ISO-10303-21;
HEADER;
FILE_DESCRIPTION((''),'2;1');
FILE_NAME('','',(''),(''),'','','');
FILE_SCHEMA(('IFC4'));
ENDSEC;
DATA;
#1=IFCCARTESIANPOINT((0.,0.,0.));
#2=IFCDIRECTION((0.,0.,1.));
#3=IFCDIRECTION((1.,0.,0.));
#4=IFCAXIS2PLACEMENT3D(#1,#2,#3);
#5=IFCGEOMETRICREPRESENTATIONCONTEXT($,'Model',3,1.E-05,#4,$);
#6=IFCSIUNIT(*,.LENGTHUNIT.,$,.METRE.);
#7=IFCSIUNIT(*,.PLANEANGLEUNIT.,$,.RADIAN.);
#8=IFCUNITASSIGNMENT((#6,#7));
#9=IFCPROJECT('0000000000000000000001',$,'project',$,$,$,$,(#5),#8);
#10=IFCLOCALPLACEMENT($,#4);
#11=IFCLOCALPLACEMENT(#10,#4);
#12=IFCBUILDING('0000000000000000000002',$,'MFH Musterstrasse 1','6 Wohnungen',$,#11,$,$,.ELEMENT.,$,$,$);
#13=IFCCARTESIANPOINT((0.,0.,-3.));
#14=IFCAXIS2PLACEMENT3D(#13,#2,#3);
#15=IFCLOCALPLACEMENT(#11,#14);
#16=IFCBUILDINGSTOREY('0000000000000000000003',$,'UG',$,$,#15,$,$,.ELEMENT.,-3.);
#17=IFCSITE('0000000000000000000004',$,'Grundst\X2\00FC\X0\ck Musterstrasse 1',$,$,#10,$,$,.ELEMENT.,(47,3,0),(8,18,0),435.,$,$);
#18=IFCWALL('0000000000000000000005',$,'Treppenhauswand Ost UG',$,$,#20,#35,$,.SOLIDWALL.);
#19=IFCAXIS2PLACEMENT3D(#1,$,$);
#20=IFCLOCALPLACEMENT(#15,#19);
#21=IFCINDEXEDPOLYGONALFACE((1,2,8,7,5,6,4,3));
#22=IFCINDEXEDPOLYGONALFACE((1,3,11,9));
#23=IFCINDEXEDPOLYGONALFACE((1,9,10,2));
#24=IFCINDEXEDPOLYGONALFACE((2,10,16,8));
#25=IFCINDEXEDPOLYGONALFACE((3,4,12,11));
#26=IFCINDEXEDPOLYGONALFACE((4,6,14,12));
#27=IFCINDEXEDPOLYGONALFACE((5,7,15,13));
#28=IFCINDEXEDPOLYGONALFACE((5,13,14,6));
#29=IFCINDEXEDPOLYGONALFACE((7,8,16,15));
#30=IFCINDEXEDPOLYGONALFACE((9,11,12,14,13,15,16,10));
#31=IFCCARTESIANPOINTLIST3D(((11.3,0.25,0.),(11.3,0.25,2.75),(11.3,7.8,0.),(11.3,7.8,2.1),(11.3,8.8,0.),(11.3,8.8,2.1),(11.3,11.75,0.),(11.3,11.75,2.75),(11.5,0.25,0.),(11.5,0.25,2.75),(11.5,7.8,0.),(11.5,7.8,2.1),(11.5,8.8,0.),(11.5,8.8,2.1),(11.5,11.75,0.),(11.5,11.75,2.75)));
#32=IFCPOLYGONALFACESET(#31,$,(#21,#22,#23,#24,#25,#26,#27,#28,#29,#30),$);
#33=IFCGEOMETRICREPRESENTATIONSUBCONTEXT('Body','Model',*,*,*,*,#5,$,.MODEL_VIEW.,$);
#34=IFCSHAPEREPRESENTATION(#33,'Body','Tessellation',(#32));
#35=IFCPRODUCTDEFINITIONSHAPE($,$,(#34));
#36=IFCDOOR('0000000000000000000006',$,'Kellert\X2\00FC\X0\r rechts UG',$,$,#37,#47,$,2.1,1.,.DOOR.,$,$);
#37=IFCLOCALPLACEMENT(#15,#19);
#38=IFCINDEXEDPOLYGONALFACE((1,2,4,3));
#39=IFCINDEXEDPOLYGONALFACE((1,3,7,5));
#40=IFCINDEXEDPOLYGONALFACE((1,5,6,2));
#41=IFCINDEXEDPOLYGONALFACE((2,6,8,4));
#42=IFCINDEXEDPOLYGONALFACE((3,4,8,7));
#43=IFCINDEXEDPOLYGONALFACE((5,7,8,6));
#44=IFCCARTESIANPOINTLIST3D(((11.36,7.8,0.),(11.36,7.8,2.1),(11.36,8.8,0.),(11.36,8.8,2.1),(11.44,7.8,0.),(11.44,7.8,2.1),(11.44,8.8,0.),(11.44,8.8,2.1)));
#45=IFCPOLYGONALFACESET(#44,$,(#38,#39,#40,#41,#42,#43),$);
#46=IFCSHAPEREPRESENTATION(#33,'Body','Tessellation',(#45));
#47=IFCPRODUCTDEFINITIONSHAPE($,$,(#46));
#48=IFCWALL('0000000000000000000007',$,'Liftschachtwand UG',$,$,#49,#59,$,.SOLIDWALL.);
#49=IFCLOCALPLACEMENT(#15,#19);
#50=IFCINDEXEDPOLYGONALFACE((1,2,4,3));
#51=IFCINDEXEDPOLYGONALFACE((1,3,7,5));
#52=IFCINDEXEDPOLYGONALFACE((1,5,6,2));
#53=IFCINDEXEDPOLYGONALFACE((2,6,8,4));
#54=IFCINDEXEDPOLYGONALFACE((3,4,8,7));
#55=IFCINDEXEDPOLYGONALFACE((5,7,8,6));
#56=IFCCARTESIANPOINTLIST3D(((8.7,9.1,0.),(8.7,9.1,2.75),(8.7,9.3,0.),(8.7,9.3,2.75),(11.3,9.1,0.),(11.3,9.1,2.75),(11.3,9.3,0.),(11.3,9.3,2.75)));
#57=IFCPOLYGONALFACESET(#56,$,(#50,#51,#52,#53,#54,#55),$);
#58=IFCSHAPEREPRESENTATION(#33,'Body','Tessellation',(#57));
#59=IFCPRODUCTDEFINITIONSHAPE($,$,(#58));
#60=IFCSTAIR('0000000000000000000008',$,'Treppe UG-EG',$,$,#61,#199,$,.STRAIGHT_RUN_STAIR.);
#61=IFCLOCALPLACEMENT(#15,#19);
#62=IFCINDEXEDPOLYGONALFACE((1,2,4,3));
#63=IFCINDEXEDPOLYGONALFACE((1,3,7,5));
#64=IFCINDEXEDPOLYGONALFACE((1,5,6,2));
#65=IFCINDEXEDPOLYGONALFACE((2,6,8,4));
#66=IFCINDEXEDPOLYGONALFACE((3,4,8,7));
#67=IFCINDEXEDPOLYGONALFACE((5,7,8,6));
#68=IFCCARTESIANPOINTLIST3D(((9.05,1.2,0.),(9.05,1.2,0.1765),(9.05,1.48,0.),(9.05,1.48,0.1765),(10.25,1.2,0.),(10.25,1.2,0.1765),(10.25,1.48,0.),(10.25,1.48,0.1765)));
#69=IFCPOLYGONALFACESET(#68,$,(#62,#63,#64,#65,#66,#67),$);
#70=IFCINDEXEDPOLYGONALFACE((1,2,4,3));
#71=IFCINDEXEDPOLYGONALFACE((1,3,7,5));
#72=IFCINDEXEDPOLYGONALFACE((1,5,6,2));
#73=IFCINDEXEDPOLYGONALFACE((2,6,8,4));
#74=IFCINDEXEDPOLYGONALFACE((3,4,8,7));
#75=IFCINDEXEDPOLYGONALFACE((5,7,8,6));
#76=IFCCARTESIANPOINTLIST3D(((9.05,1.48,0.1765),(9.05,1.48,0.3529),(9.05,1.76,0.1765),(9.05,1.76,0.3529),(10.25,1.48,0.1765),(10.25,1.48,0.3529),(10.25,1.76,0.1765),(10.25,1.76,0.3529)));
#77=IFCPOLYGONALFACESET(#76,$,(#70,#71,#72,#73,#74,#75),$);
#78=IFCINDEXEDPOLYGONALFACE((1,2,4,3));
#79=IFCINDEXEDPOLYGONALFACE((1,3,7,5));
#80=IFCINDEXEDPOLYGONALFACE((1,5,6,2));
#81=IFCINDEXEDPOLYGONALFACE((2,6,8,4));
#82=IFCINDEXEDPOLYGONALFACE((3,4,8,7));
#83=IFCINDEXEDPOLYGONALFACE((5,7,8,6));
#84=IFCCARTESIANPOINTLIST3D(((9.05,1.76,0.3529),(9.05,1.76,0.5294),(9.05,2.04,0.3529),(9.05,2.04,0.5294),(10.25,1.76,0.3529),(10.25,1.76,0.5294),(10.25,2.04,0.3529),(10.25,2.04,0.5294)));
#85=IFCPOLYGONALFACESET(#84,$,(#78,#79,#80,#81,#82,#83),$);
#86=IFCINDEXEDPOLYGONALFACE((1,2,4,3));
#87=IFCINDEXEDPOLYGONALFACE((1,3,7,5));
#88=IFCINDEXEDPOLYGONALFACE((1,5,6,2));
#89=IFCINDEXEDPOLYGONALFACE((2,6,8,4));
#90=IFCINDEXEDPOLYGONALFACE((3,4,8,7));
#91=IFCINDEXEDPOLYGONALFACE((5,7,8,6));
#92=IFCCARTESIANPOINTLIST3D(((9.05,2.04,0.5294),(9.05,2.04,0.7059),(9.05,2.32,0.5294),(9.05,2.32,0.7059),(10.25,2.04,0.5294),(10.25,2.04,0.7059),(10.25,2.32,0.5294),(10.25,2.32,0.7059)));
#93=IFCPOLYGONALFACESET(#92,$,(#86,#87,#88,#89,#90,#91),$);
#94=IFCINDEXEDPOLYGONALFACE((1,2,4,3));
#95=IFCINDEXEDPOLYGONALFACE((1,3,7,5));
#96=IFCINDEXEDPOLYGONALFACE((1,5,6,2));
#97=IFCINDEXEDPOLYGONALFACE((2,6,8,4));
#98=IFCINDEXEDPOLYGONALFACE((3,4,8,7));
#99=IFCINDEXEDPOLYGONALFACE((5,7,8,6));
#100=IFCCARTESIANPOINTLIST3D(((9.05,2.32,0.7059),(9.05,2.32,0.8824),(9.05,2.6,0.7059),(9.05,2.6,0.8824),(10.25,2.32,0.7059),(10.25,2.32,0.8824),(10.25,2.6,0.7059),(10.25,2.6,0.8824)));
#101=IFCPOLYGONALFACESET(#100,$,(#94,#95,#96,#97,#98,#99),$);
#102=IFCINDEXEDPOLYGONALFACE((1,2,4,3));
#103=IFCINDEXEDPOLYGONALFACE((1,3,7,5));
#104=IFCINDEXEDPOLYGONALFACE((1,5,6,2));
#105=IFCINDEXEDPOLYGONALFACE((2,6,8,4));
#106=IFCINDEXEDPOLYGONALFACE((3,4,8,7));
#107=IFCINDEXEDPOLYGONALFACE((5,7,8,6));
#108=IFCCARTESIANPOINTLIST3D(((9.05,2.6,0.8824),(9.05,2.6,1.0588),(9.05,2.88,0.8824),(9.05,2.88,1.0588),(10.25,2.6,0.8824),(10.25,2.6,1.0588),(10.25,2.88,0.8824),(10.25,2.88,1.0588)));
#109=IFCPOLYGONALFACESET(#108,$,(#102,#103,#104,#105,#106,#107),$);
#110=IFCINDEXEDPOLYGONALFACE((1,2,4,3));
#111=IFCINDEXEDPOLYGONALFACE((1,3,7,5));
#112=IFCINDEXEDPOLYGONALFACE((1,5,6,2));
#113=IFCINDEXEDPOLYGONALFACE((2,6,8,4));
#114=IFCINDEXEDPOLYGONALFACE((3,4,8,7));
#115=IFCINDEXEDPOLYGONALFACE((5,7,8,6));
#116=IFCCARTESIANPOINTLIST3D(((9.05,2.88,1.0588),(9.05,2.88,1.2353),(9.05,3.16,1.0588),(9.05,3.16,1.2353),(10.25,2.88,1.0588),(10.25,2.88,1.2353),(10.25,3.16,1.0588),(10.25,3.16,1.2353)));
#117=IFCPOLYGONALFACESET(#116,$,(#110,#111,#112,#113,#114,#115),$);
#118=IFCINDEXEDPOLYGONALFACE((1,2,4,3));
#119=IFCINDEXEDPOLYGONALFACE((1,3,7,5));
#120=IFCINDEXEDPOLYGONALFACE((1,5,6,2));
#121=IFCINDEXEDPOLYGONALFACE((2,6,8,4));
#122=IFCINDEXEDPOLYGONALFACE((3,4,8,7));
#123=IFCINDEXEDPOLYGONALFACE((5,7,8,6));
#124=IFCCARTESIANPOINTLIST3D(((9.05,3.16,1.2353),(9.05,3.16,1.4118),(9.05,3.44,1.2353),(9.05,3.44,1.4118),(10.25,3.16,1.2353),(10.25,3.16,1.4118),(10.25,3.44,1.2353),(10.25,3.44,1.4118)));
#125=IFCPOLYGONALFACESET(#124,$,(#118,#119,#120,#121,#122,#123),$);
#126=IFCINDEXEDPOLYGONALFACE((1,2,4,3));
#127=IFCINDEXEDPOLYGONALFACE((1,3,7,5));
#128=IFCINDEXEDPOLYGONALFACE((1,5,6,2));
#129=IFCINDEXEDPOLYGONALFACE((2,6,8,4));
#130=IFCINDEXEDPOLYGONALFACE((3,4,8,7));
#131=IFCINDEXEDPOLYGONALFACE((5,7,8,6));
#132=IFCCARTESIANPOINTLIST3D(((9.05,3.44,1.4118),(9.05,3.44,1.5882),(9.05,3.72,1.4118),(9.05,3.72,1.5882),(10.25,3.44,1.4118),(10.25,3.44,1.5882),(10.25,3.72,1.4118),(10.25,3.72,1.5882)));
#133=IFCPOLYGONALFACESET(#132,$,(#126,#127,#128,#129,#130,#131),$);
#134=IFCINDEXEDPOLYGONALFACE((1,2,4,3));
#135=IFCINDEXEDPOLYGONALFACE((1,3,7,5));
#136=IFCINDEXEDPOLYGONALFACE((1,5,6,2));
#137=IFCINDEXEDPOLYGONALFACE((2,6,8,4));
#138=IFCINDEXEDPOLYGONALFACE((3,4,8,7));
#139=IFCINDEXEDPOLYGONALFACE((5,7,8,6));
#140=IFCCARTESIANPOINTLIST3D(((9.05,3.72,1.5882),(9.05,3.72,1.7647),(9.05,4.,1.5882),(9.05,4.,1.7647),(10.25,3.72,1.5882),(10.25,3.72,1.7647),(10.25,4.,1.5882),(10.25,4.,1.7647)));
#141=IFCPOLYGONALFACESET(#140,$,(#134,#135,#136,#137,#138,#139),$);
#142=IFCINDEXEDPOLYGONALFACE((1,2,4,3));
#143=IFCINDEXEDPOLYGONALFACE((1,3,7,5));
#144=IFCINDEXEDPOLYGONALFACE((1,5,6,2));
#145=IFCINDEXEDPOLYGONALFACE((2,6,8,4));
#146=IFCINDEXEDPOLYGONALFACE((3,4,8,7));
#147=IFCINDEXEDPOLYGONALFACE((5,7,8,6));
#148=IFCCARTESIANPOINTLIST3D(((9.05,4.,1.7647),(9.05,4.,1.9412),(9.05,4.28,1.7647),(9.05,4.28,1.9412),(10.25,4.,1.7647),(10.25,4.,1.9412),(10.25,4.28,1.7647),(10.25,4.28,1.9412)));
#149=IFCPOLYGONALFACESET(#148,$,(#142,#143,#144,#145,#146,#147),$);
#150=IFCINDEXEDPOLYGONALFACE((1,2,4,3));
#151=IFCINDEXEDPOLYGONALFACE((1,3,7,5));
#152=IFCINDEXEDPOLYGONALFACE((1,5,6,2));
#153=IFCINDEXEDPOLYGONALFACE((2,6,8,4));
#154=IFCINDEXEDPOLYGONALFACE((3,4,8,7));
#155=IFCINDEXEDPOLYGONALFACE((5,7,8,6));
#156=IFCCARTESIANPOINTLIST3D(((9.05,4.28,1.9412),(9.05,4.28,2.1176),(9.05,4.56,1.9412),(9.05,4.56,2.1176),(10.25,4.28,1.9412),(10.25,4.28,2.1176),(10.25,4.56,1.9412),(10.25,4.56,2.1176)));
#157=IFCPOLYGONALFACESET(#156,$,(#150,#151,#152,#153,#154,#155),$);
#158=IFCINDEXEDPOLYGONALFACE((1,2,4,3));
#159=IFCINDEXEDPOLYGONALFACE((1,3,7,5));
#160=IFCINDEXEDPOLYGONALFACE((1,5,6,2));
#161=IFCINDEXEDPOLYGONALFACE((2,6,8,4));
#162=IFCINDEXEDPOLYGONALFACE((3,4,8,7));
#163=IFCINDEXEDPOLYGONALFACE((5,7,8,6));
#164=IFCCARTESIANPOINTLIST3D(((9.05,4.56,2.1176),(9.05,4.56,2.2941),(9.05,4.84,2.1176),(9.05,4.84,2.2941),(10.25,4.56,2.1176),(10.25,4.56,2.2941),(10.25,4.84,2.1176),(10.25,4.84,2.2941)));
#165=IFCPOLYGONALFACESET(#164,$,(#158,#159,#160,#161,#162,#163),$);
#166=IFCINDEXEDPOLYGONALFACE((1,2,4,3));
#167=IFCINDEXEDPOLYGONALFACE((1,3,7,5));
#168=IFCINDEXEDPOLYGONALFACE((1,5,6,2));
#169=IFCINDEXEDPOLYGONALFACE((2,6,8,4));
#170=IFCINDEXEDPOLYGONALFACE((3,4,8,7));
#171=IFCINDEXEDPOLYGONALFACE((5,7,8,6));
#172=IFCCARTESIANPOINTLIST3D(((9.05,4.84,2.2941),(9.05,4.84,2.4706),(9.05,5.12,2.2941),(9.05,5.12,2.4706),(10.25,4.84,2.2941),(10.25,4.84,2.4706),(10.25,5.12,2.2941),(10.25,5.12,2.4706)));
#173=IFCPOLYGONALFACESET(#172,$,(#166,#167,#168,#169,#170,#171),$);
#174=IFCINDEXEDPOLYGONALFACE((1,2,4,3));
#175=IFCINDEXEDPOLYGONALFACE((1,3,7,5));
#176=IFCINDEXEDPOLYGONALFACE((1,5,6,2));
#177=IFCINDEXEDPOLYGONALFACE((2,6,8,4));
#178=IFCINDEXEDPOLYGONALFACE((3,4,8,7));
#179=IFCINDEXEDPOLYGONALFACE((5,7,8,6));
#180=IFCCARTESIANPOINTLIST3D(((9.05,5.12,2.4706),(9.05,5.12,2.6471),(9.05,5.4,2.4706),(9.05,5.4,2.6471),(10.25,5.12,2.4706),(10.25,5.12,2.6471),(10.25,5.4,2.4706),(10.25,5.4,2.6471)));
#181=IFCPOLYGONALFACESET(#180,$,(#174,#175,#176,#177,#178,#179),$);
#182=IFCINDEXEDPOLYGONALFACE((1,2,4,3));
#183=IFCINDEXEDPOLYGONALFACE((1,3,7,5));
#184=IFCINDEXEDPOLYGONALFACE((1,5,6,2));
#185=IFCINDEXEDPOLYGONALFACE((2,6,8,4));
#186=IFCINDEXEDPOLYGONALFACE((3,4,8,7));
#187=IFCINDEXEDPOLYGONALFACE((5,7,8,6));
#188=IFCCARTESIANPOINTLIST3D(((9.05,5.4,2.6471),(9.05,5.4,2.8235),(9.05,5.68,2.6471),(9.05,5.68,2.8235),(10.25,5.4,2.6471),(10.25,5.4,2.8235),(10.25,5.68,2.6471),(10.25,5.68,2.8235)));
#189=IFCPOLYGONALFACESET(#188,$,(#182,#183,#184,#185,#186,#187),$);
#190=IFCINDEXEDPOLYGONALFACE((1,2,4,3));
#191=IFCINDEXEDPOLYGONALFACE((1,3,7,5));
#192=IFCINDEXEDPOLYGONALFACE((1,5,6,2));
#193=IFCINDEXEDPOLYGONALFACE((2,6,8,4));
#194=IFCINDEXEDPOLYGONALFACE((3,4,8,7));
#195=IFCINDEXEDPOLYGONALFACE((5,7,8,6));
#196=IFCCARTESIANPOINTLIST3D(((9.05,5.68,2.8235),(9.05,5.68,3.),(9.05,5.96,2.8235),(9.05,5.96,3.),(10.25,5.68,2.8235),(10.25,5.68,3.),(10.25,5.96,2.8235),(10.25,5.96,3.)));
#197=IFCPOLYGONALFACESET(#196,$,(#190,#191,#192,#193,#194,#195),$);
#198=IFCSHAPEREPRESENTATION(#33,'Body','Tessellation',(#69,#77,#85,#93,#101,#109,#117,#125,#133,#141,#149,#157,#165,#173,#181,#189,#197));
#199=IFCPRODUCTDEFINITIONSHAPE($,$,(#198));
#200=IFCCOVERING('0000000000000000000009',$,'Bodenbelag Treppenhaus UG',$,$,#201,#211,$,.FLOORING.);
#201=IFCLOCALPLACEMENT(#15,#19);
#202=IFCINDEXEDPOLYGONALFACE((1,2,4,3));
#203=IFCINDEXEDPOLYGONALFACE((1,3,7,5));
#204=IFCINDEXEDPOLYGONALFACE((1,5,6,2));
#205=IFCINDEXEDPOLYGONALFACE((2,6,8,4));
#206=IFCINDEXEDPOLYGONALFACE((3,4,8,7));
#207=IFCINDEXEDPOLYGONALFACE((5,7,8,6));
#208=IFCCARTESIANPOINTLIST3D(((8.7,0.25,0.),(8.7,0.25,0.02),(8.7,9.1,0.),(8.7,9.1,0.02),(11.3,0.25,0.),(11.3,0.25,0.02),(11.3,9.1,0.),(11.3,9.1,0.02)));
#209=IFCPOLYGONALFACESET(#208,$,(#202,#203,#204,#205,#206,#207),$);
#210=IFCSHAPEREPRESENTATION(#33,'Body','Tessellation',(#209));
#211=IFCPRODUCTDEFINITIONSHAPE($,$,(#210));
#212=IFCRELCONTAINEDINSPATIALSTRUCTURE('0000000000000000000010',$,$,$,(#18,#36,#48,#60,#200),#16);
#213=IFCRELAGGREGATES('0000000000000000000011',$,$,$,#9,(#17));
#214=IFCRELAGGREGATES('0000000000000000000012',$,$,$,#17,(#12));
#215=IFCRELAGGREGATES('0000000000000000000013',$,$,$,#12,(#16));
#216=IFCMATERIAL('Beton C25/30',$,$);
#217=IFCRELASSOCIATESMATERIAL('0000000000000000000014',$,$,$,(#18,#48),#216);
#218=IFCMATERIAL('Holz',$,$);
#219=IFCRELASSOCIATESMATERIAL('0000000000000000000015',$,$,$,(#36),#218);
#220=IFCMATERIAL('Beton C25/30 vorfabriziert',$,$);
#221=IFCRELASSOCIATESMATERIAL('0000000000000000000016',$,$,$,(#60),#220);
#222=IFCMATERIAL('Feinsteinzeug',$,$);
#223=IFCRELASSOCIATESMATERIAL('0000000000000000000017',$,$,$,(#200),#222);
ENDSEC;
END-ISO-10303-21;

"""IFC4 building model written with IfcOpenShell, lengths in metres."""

from ifc_helpers import new_model, si_unit, frame, frame_2d, origin_with_axes, place, context, subcontext, project, spatial, rectangle, extrude, material, element, fill, save


model = new_model("IFC4")

# Units and contexts
model_context = context("Model", 3, precision=1e-05, world=origin_with_axes())
body_context = subcontext(model_context, "Body", "Model", "MODEL_VIEW")
ifc_project = project(units=[si_unit("LENGTHUNIT", "METRE"), si_unit("PLANEANGLEUNIT", "RADIAN")], contexts=[model_context])

# Site, building, storey
site_placement = place(None, origin_with_axes())
site = spatial("IfcSite", under=ifc_project, at=site_placement, Name="Grundstück Musterstrasse 1", CompositionType="ELEMENT", RefLatitude=(47, 3, 0), RefLongitude=(8, 18, 0), RefElevation=435.0)
building_placement = place(site_placement, origin_with_axes())
building = spatial("IfcBuilding", under=site, at=building_placement, Name="MFH Musterstrasse 1", Description="6 Wohnungen", CompositionType="ELEMENT")
storey_placement = place(building_placement, frame((0.0, 0.0, -3.0), z_axis=(0.0, 0.0, 1.0), x_axis=(1.0, 0.0, 0.0)))
storey = spatial("IfcBuildingStorey", under=building, at=storey_placement, Name="UG", CompositionType="ELEMENT", Elevation=-3.0)

# Shared definitions
ifc_material_1 = material(Name="Beton C25/30")

# Wall, openings, door
ifc_material_2 = material(Name="Holz")
wall_1_placement = place(storey_placement, origin_with_axes())
wall_1 = element("IfcWall", 1, at=wall_1_placement, inside=storey, material=ifc_material_1, Name="Treppenhauswand Ost UG", PredefinedType="SOLIDWALL", context=body_context, shape_type="SweptSolid", body=[
    extrude(rectangle(XDim=0.2, YDim=11.5, at=frame_2d((0.1, 5.75), x_axis=(1.0, 0.0))), frame((11.3, 0.25, 0.0), z_axis=(0.0, 0.0, 1.0), x_axis=(1.0, 0.0, 0.0)), (0.0, 0.0, 1.0), 2.75),
])
opening_1_placement = place(storey_placement, origin_with_axes())
element("IfcOpeningElement", 2, at=opening_1_placement, cuts=wall_1, PredefinedType="OPENING", context=body_context, shape_type="SweptSolid", body=[
    extrude(rectangle(XDim=0.3, YDim=1.0, at=frame_2d((0.15, 0.5), x_axis=(1.0, 0.0))), frame((11.25, 7.8, 0.0), z_axis=(0.0, 0.0, 1.0), x_axis=(1.0, 0.0, 0.0)), (0.0, 0.0, 1.0), 2.1),
])
opening_2_placement = place(storey_placement, origin_with_axes())
opening_2 = element("IfcOpeningElement", 3, at=opening_2_placement, cuts=wall_1, PredefinedType="OPENING", context=body_context, shape_type="SweptSolid", body=[
    extrude(rectangle(XDim=0.22, YDim=1.0, at=frame_2d((0.11, 0.5), x_axis=(1.0, 0.0))), frame((11.29, 7.8, 0.0), z_axis=(0.0, 0.0, 1.0), x_axis=(1.0, 0.0, 0.0)), (0.0, 0.0, 1.0), 2.1),
])
door_1_placement = place(storey_placement, origin_with_axes())
door_1 = element("IfcDoor", 4, at=door_1_placement, inside=storey, material=ifc_material_2, Name="Kellertür rechts UG", OverallHeight=2.1, OverallWidth=1.0, PredefinedType="DOOR", context=body_context, shape_type="SweptSolid", body=[
    extrude(rectangle(XDim=0.08, YDim=1.0, at=frame_2d((0.04, 0.5), x_axis=(1.0, 0.0))), frame((11.36, 7.8, 0.0), z_axis=(0.0, 0.0, 1.0), x_axis=(1.0, 0.0, 0.0)), (0.0, 0.0, 1.0), 2.1),
])
fill(opening_2, door_1)

# Wall
wall_2_placement = place(storey_placement, origin_with_axes())
element("IfcWall", 5, at=wall_2_placement, inside=storey, material=ifc_material_1, Name="Liftschachtwand UG", PredefinedType="SOLIDWALL", context=body_context, shape_type="SweptSolid", body=[
    extrude(rectangle(XDim=2.6, YDim=0.2, at=frame_2d((1.3, 0.1), x_axis=(1.0, 0.0))), frame((8.7, 9.1, 0.0), z_axis=(0.0, 0.0, 1.0), x_axis=(1.0, 0.0, 0.0)), (0.0, 0.0, 1.0), 2.75),
])

# Stair
ifc_material_3 = material(Name="Beton C25/30 vorfabriziert")
stair_placement = place(storey_placement, origin_with_axes())
element("IfcStair", 6, at=stair_placement, inside=storey, material=ifc_material_3, Name="Treppe UG-EG", PredefinedType="STRAIGHT_RUN_STAIR", context=body_context, shape_type="SweptSolid", body=[
    extrude(rectangle(XDim=1.2, YDim=0.28, at=frame_2d((0.6, 0.14), x_axis=(1.0, 0.0))), frame((9.05, 1.2, 0.0), z_axis=(0.0, 0.0, 1.0), x_axis=(1.0, 0.0, 0.0)), (0.0, 0.0, 1.0), 0.1765),
    extrude(rectangle(XDim=1.2, YDim=0.28, at=frame_2d((0.6, 0.14), x_axis=(1.0, 0.0))), frame((9.05, 1.48, 0.1765), z_axis=(0.0, 0.0, 1.0), x_axis=(1.0, 0.0, 0.0)), (0.0, 0.0, 1.0), 0.1765),
    extrude(rectangle(XDim=1.2, YDim=0.28, at=frame_2d((0.6, 0.14), x_axis=(1.0, 0.0))), frame((9.05, 1.76, 0.3529), z_axis=(0.0, 0.0, 1.0), x_axis=(1.0, 0.0, 0.0)), (0.0, 0.0, 1.0), 0.1765),
    extrude(rectangle(XDim=1.2, YDim=0.28, at=frame_2d((0.6, 0.14), x_axis=(1.0, 0.0))), frame((9.05, 2.04, 0.5294), z_axis=(0.0, 0.0, 1.0), x_axis=(1.0, 0.0, 0.0)), (0.0, 0.0, 1.0), 0.1765),
    extrude(rectangle(XDim=1.2, YDim=0.28, at=frame_2d((0.6, 0.14), x_axis=(1.0, 0.0))), frame((9.05, 2.32, 0.7059), z_axis=(0.0, 0.0, 1.0), x_axis=(1.0, 0.0, 0.0)), (0.0, 0.0, 1.0), 0.1765),
    extrude(rectangle(XDim=1.2, YDim=0.28, at=frame_2d((0.6, 0.14), x_axis=(1.0, 0.0))), frame((9.05, 2.6, 0.8824), z_axis=(0.0, 0.0, 1.0), x_axis=(1.0, 0.0, 0.0)), (0.0, 0.0, 1.0), 0.1765),
    extrude(rectangle(XDim=1.2, YDim=0.28, at=frame_2d((0.6, 0.14), x_axis=(1.0, 0.0))), frame((9.05, 2.88, 1.0588), z_axis=(0.0, 0.0, 1.0), x_axis=(1.0, 0.0, 0.0)), (0.0, 0.0, 1.0), 0.1765),
    extrude(rectangle(XDim=1.2, YDim=0.28, at=frame_2d((0.6, 0.14), x_axis=(1.0, 0.0))), frame((9.05, 3.16, 1.2353), z_axis=(0.0, 0.0, 1.0), x_axis=(1.0, 0.0, 0.0)), (0.0, 0.0, 1.0), 0.1765),
    extrude(rectangle(XDim=1.2, YDim=0.28, at=frame_2d((0.6, 0.14), x_axis=(1.0, 0.0))), frame((9.05, 3.44, 1.4118), z_axis=(0.0, 0.0, 1.0), x_axis=(1.0, 0.0, 0.0)), (0.0, 0.0, 1.0), 0.1765),
    extrude(rectangle(XDim=1.2, YDim=0.28, at=frame_2d((0.6, 0.14), x_axis=(1.0, 0.0))), frame((9.05, 3.72, 1.5882), z_axis=(0.0, 0.0, 1.0), x_axis=(1.0, 0.0, 0.0)), (0.0, 0.0, 1.0), 0.1765),
    extrude(rectangle(XDim=1.2, YDim=0.28, at=frame_2d((0.6, 0.14), x_axis=(1.0, 0.0))), frame((9.05, 4.0, 1.7647), z_axis=(0.0, 0.0, 1.0), x_axis=(1.0, 0.0, 0.0)), (0.0, 0.0, 1.0), 0.1765),
    extrude(rectangle(XDim=1.2, YDim=0.28, at=frame_2d((0.6, 0.14), x_axis=(1.0, 0.0))), frame((9.05, 4.28, 1.9412), z_axis=(0.0, 0.0, 1.0), x_axis=(1.0, 0.0, 0.0)), (0.0, 0.0, 1.0), 0.1765),
    extrude(rectangle(XDim=1.2, YDim=0.28, at=frame_2d((0.6, 0.14), x_axis=(1.0, 0.0))), frame((9.05, 4.56, 2.1176), z_axis=(0.0, 0.0, 1.0), x_axis=(1.0, 0.0, 0.0)), (0.0, 0.0, 1.0), 0.1765),
    extrude(rectangle(XDim=1.2, YDim=0.28, at=frame_2d((0.6, 0.14), x_axis=(1.0, 0.0))), frame((9.05, 4.84, 2.2941), z_axis=(0.0, 0.0, 1.0), x_axis=(1.0, 0.0, 0.0)), (0.0, 0.0, 1.0), 0.1765),
    extrude(rectangle(XDim=1.2, YDim=0.28, at=frame_2d((0.6, 0.14), x_axis=(1.0, 0.0))), frame((9.05, 5.12, 2.4706), z_axis=(0.0, 0.0, 1.0), x_axis=(1.0, 0.0, 0.0)), (0.0, 0.0, 1.0), 0.1765),
    extrude(rectangle(XDim=1.2, YDim=0.28, at=frame_2d((0.6, 0.14), x_axis=(1.0, 0.0))), frame((9.05, 5.4, 2.6471), z_axis=(0.0, 0.0, 1.0), x_axis=(1.0, 0.0, 0.0)), (0.0, 0.0, 1.0), 0.1765),
    extrude(rectangle(XDim=1.2, YDim=0.28, at=frame_2d((0.6, 0.14), x_axis=(1.0, 0.0))), frame((9.05, 5.68, 2.8235), z_axis=(0.0, 0.0, 1.0), x_axis=(1.0, 0.0, 0.0)), (0.0, 0.0, 1.0), 0.1765),
])

# Covering
ifc_material_4 = material(Name="Feinsteinzeug")
covering_1_placement = place(storey_placement, origin_with_axes())
element("IfcCovering", 7, at=covering_1_placement, inside=storey, material=ifc_material_4, Name="Bodenbelag Treppenhaus UG", PredefinedType="FLOORING", context=body_context, shape_type="SweptSolid", body=[
    extrude(rectangle(XDim=2.6, YDim=8.85, at=frame_2d((1.3, 4.425), x_axis=(1.0, 0.0))), frame((8.7, 0.25, 0.0), z_axis=(0.0, 0.0, 1.0), x_axis=(1.0, 0.0, 0.0)), (0.0, 0.0, 1.0), 0.02),
])

save(model, "model.ifc")
